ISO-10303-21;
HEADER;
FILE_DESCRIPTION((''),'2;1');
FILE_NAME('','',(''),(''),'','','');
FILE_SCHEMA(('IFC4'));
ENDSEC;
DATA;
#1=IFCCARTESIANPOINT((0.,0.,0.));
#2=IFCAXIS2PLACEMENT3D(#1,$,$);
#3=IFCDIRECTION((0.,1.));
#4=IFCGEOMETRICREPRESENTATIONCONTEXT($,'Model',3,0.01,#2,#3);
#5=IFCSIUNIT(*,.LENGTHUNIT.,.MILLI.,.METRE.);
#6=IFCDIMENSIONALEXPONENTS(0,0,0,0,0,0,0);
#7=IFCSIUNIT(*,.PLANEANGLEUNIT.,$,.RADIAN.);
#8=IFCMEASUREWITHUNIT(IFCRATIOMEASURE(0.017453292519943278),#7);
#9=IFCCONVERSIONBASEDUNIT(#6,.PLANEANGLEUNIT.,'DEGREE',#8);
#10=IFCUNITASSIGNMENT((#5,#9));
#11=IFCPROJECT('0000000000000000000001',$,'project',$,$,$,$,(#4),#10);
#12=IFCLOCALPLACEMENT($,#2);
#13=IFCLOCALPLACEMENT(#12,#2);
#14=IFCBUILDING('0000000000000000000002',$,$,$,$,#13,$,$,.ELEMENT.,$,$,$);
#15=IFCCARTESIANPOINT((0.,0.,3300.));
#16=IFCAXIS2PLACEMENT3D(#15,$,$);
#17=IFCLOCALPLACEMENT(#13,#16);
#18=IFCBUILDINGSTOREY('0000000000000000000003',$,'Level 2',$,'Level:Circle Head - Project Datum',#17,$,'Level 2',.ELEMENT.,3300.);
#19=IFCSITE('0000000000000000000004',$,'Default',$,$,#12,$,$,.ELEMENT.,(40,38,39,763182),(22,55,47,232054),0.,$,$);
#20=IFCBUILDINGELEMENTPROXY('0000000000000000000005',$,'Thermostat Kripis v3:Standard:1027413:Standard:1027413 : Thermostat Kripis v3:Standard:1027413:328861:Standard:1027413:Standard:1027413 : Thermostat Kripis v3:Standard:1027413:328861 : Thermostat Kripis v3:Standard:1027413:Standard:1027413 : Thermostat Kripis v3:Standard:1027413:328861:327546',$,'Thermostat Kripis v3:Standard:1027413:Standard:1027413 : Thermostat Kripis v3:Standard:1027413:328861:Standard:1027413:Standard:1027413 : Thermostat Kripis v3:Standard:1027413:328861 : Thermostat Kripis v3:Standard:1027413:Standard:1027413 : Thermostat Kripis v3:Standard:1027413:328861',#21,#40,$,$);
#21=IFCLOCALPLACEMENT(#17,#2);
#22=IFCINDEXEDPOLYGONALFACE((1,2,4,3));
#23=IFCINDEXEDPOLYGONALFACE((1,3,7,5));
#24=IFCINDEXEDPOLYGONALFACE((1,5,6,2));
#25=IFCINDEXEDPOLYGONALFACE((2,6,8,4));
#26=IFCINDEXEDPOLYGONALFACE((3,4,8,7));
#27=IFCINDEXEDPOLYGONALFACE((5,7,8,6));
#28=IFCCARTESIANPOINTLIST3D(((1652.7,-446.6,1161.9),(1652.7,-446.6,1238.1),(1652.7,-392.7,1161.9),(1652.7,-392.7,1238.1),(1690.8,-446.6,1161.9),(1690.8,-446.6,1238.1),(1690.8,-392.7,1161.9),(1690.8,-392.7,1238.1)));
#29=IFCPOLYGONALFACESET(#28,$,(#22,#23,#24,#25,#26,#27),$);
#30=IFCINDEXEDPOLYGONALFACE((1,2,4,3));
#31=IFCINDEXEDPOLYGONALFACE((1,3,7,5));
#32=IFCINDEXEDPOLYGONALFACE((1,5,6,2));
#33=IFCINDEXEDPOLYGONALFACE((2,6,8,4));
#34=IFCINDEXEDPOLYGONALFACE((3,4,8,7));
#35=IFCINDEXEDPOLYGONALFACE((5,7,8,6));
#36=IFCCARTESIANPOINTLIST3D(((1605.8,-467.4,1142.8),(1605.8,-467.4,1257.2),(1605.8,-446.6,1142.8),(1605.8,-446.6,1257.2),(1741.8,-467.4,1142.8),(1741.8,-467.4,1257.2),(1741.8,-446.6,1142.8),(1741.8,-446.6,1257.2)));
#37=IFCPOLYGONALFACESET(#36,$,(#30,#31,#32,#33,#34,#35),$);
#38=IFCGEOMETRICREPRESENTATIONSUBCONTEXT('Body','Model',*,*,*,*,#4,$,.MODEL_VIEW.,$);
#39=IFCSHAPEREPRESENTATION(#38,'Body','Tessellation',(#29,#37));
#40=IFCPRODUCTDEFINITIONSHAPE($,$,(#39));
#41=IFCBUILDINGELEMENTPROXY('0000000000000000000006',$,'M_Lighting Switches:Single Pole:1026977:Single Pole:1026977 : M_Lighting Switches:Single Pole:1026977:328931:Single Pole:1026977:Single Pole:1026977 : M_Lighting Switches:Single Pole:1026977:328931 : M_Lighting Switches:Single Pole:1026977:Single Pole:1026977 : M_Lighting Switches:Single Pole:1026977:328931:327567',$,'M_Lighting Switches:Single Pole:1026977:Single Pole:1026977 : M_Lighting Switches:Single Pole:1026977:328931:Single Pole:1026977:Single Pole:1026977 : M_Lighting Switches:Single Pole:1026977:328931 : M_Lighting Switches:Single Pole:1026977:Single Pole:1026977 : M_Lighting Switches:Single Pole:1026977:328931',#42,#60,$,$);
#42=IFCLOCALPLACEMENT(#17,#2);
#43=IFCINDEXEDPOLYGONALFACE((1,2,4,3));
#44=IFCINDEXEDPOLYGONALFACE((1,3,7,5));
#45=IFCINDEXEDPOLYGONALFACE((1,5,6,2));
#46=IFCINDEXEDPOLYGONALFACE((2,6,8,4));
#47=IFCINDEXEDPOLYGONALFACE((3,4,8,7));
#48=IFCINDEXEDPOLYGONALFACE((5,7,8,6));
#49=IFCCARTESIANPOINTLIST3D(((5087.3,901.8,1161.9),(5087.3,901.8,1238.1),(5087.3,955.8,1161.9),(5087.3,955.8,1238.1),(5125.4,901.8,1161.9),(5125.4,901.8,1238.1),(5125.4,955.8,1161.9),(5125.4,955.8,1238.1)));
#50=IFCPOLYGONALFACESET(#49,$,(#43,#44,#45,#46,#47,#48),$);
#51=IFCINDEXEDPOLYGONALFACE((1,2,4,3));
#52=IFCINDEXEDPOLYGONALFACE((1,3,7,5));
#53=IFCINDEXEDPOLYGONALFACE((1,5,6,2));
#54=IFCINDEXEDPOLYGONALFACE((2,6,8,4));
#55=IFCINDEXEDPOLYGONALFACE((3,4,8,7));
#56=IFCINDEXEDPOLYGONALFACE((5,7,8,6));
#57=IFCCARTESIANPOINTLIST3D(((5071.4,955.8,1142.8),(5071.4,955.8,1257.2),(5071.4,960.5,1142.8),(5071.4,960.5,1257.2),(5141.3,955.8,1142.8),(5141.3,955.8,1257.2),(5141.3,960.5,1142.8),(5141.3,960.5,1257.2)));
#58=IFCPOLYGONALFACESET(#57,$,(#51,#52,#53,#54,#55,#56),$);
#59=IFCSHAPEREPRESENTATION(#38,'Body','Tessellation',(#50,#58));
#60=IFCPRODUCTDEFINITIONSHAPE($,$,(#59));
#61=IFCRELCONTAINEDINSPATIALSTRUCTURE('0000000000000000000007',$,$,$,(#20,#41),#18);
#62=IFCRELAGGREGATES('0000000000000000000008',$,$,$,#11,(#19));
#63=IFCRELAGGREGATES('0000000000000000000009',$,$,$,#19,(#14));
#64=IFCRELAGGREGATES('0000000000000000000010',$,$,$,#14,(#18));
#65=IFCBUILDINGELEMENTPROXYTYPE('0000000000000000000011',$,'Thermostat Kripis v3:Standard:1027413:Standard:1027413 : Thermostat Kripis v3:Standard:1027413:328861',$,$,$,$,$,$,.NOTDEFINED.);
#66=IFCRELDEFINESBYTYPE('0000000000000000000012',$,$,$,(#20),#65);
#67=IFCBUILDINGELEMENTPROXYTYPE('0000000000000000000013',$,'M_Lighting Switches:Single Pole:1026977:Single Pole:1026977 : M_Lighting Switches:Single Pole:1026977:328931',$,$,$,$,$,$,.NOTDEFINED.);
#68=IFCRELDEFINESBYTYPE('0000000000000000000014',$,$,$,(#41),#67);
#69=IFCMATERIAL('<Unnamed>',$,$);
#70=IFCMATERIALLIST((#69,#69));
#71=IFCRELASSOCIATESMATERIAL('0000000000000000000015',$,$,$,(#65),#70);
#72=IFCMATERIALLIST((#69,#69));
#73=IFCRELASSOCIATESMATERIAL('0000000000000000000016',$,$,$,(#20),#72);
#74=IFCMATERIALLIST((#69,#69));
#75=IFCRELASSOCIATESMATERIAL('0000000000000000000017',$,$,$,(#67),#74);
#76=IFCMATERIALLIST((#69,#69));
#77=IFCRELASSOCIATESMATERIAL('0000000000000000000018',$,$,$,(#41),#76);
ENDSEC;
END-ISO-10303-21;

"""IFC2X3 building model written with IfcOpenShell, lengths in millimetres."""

from ifc_helpers import new_model, entity, si_unit, converted_unit, direction, frame, frame_2d, origin, origin_2d_with_axis, place, context, subcontext, project, spatial, rectangle, extrude, source, transform, mapped, material, material_list, type_object, type_shapes, element, save


model = new_model("IFC2X3")

# Units and contexts
model_context = context("Model", 3, precision=0.01, world=origin(), true_north=direction((0.0, 1.0)))
body_context = subcontext(model_context, "Body", "Model", "MODEL_VIEW")
ifc_project = project(units=[si_unit("LENGTHUNIT", "METRE", prefix="MILLI"), converted_unit("PLANEANGLEUNIT", "DEGREE", entity("IfcRatioMeasure", 0.017453292519943278), si_unit("PLANEANGLEUNIT", "RADIAN"), dimensions=[0, 0, 0, 0, 0, 0, 0])], contexts=[model_context])

# Site, building, storey
site_placement = place(None, origin())
site = spatial("IfcSite", under=ifc_project, at=site_placement, Name="Default", CompositionType="ELEMENT", RefLatitude=(40, 38, 39, 763182), RefLongitude=(22, 55, 47, 232054), RefElevation=0.0)
building_placement = place(site_placement, origin())
building = spatial("IfcBuilding", under=site, at=building_placement, CompositionType="ELEMENT")
storey_placement = place(building_placement, frame((0.0, 0.0, 3300.0)))
storey = spatial("IfcBuildingStorey", under=building, at=storey_placement, Name="Level 2", ObjectType="Level:Circle Head - Project Datum", LongName="Level 2", CompositionType="ELEMENT", Elevation=3300.0)

# Shared definitions
ifc_material_1 = material(Name="<Unnamed>")

# Building element proxies
ifc_material_list_1 = material_list([ifc_material_1, ifc_material_1])
ifc_material_list_2 = material_list([ifc_material_1, ifc_material_1])
building_element_proxy_type_1 = type_object("IfcBuildingElementProxyType", Name="Thermostat Kripis v3:Standard:1027413:Standard:1027413 : Thermostat Kripis v3:Standard:1027413:328861", PredefinedType="NOTDEFINED", material=ifc_material_list_2)
shared_shape_1 = source(origin(), body_context, "Body", "SweptSolid", [
    extrude(rectangle(XDim=38.1, YDim=54.0, at=frame_2d((0.0, 0.0), x_axis=(1.0, 0.0))), frame((1671.7, -419.7, 4461.9), z_axis=(0.0, 0.0, 1.0), x_axis=(-1.0, 0.0, 0.0)), (0.0, 0.0, 1.0), 76.2),
    extrude(rectangle(XDim=136.0, YDim=20.7, at=origin_2d_with_axis()), frame((1673.8, -457.0, 4442.8), z_axis=(0.0, 0.0, 1.0), x_axis=(-1.0, 0.0, 0.0)), (0.0, 0.0, 1.0), 114.3),
])
type_shapes(building_element_proxy_type_1, [shared_shape_1])
proxy_1_placement = place(storey_placement, frame((0.0, 0.0, -3300.0)))
element("IfcBuildingElementProxy", 1, at=proxy_1_placement, inside=storey, type_object=building_element_proxy_type_1, material=ifc_material_list_1, Name="Thermostat Kripis v3:Standard:1027413:Standard:1027413 : Thermostat Kripis v3:Standard:1027413:328861:Standard:1027413:Standard:1027413 : Thermostat Kripis v3:Standard:1027413:328861 : Thermostat Kripis v3:Standard:1027413:Standard:1027413 : Thermostat Kripis v3:Standard:1027413:328861:327546", ObjectType="Thermostat Kripis v3:Standard:1027413:Standard:1027413 : Thermostat Kripis v3:Standard:1027413:328861:Standard:1027413:Standard:1027413 : Thermostat Kripis v3:Standard:1027413:328861 : Thermostat Kripis v3:Standard:1027413:Standard:1027413 : Thermostat Kripis v3:Standard:1027413:328861", context=body_context, shape_type="MappedRepresentation", body=[
    mapped(shared_shape_1, transform((0.0, 0.0, 0.0), scale=1.0)),
])
ifc_material_list_3 = material_list([ifc_material_1, ifc_material_1])
ifc_material_list_4 = material_list([ifc_material_1, ifc_material_1])
building_element_proxy_type_2 = type_object("IfcBuildingElementProxyType", Name="M_Lighting Switches:Single Pole:1026977:Single Pole:1026977 : M_Lighting Switches:Single Pole:1026977:328931", PredefinedType="NOTDEFINED", material=ifc_material_list_4)
shared_shape_2 = source(origin(), body_context, "Body", "SweptSolid", [
    extrude(rectangle(XDim=38.1, YDim=54.0, at=origin_2d_with_axis()), frame((5106.4, 928.8, 4461.9)), (0.0, 0.0, 1.0), 76.2),
    extrude(rectangle(XDim=69.8, YDim=4.8, at=frame_2d((0.0, 0.0), x_axis=(1.0, 0.0))), frame((5106.4, 958.1, 4442.8)), (0.0, 0.0, 1.0), 114.3),
])
type_shapes(building_element_proxy_type_2, [shared_shape_2])
proxy_2_placement = place(storey_placement, frame((0.0, 0.0, -3300.0)))
element("IfcBuildingElementProxy", 2, at=proxy_2_placement, inside=storey, type_object=building_element_proxy_type_2, material=ifc_material_list_3, Name="M_Lighting Switches:Single Pole:1026977:Single Pole:1026977 : M_Lighting Switches:Single Pole:1026977:328931:Single Pole:1026977:Single Pole:1026977 : M_Lighting Switches:Single Pole:1026977:328931 : M_Lighting Switches:Single Pole:1026977:Single Pole:1026977 : M_Lighting Switches:Single Pole:1026977:328931:327567", ObjectType="M_Lighting Switches:Single Pole:1026977:Single Pole:1026977 : M_Lighting Switches:Single Pole:1026977:328931:Single Pole:1026977:Single Pole:1026977 : M_Lighting Switches:Single Pole:1026977:328931 : M_Lighting Switches:Single Pole:1026977:Single Pole:1026977 : M_Lighting Switches:Single Pole:1026977:328931", context=body_context, shape_type="MappedRepresentation", body=[
    mapped(shared_shape_2, transform((0.0, 0.0, 0.0), scale=1.0)),
])

save(model, "model.ifc")
